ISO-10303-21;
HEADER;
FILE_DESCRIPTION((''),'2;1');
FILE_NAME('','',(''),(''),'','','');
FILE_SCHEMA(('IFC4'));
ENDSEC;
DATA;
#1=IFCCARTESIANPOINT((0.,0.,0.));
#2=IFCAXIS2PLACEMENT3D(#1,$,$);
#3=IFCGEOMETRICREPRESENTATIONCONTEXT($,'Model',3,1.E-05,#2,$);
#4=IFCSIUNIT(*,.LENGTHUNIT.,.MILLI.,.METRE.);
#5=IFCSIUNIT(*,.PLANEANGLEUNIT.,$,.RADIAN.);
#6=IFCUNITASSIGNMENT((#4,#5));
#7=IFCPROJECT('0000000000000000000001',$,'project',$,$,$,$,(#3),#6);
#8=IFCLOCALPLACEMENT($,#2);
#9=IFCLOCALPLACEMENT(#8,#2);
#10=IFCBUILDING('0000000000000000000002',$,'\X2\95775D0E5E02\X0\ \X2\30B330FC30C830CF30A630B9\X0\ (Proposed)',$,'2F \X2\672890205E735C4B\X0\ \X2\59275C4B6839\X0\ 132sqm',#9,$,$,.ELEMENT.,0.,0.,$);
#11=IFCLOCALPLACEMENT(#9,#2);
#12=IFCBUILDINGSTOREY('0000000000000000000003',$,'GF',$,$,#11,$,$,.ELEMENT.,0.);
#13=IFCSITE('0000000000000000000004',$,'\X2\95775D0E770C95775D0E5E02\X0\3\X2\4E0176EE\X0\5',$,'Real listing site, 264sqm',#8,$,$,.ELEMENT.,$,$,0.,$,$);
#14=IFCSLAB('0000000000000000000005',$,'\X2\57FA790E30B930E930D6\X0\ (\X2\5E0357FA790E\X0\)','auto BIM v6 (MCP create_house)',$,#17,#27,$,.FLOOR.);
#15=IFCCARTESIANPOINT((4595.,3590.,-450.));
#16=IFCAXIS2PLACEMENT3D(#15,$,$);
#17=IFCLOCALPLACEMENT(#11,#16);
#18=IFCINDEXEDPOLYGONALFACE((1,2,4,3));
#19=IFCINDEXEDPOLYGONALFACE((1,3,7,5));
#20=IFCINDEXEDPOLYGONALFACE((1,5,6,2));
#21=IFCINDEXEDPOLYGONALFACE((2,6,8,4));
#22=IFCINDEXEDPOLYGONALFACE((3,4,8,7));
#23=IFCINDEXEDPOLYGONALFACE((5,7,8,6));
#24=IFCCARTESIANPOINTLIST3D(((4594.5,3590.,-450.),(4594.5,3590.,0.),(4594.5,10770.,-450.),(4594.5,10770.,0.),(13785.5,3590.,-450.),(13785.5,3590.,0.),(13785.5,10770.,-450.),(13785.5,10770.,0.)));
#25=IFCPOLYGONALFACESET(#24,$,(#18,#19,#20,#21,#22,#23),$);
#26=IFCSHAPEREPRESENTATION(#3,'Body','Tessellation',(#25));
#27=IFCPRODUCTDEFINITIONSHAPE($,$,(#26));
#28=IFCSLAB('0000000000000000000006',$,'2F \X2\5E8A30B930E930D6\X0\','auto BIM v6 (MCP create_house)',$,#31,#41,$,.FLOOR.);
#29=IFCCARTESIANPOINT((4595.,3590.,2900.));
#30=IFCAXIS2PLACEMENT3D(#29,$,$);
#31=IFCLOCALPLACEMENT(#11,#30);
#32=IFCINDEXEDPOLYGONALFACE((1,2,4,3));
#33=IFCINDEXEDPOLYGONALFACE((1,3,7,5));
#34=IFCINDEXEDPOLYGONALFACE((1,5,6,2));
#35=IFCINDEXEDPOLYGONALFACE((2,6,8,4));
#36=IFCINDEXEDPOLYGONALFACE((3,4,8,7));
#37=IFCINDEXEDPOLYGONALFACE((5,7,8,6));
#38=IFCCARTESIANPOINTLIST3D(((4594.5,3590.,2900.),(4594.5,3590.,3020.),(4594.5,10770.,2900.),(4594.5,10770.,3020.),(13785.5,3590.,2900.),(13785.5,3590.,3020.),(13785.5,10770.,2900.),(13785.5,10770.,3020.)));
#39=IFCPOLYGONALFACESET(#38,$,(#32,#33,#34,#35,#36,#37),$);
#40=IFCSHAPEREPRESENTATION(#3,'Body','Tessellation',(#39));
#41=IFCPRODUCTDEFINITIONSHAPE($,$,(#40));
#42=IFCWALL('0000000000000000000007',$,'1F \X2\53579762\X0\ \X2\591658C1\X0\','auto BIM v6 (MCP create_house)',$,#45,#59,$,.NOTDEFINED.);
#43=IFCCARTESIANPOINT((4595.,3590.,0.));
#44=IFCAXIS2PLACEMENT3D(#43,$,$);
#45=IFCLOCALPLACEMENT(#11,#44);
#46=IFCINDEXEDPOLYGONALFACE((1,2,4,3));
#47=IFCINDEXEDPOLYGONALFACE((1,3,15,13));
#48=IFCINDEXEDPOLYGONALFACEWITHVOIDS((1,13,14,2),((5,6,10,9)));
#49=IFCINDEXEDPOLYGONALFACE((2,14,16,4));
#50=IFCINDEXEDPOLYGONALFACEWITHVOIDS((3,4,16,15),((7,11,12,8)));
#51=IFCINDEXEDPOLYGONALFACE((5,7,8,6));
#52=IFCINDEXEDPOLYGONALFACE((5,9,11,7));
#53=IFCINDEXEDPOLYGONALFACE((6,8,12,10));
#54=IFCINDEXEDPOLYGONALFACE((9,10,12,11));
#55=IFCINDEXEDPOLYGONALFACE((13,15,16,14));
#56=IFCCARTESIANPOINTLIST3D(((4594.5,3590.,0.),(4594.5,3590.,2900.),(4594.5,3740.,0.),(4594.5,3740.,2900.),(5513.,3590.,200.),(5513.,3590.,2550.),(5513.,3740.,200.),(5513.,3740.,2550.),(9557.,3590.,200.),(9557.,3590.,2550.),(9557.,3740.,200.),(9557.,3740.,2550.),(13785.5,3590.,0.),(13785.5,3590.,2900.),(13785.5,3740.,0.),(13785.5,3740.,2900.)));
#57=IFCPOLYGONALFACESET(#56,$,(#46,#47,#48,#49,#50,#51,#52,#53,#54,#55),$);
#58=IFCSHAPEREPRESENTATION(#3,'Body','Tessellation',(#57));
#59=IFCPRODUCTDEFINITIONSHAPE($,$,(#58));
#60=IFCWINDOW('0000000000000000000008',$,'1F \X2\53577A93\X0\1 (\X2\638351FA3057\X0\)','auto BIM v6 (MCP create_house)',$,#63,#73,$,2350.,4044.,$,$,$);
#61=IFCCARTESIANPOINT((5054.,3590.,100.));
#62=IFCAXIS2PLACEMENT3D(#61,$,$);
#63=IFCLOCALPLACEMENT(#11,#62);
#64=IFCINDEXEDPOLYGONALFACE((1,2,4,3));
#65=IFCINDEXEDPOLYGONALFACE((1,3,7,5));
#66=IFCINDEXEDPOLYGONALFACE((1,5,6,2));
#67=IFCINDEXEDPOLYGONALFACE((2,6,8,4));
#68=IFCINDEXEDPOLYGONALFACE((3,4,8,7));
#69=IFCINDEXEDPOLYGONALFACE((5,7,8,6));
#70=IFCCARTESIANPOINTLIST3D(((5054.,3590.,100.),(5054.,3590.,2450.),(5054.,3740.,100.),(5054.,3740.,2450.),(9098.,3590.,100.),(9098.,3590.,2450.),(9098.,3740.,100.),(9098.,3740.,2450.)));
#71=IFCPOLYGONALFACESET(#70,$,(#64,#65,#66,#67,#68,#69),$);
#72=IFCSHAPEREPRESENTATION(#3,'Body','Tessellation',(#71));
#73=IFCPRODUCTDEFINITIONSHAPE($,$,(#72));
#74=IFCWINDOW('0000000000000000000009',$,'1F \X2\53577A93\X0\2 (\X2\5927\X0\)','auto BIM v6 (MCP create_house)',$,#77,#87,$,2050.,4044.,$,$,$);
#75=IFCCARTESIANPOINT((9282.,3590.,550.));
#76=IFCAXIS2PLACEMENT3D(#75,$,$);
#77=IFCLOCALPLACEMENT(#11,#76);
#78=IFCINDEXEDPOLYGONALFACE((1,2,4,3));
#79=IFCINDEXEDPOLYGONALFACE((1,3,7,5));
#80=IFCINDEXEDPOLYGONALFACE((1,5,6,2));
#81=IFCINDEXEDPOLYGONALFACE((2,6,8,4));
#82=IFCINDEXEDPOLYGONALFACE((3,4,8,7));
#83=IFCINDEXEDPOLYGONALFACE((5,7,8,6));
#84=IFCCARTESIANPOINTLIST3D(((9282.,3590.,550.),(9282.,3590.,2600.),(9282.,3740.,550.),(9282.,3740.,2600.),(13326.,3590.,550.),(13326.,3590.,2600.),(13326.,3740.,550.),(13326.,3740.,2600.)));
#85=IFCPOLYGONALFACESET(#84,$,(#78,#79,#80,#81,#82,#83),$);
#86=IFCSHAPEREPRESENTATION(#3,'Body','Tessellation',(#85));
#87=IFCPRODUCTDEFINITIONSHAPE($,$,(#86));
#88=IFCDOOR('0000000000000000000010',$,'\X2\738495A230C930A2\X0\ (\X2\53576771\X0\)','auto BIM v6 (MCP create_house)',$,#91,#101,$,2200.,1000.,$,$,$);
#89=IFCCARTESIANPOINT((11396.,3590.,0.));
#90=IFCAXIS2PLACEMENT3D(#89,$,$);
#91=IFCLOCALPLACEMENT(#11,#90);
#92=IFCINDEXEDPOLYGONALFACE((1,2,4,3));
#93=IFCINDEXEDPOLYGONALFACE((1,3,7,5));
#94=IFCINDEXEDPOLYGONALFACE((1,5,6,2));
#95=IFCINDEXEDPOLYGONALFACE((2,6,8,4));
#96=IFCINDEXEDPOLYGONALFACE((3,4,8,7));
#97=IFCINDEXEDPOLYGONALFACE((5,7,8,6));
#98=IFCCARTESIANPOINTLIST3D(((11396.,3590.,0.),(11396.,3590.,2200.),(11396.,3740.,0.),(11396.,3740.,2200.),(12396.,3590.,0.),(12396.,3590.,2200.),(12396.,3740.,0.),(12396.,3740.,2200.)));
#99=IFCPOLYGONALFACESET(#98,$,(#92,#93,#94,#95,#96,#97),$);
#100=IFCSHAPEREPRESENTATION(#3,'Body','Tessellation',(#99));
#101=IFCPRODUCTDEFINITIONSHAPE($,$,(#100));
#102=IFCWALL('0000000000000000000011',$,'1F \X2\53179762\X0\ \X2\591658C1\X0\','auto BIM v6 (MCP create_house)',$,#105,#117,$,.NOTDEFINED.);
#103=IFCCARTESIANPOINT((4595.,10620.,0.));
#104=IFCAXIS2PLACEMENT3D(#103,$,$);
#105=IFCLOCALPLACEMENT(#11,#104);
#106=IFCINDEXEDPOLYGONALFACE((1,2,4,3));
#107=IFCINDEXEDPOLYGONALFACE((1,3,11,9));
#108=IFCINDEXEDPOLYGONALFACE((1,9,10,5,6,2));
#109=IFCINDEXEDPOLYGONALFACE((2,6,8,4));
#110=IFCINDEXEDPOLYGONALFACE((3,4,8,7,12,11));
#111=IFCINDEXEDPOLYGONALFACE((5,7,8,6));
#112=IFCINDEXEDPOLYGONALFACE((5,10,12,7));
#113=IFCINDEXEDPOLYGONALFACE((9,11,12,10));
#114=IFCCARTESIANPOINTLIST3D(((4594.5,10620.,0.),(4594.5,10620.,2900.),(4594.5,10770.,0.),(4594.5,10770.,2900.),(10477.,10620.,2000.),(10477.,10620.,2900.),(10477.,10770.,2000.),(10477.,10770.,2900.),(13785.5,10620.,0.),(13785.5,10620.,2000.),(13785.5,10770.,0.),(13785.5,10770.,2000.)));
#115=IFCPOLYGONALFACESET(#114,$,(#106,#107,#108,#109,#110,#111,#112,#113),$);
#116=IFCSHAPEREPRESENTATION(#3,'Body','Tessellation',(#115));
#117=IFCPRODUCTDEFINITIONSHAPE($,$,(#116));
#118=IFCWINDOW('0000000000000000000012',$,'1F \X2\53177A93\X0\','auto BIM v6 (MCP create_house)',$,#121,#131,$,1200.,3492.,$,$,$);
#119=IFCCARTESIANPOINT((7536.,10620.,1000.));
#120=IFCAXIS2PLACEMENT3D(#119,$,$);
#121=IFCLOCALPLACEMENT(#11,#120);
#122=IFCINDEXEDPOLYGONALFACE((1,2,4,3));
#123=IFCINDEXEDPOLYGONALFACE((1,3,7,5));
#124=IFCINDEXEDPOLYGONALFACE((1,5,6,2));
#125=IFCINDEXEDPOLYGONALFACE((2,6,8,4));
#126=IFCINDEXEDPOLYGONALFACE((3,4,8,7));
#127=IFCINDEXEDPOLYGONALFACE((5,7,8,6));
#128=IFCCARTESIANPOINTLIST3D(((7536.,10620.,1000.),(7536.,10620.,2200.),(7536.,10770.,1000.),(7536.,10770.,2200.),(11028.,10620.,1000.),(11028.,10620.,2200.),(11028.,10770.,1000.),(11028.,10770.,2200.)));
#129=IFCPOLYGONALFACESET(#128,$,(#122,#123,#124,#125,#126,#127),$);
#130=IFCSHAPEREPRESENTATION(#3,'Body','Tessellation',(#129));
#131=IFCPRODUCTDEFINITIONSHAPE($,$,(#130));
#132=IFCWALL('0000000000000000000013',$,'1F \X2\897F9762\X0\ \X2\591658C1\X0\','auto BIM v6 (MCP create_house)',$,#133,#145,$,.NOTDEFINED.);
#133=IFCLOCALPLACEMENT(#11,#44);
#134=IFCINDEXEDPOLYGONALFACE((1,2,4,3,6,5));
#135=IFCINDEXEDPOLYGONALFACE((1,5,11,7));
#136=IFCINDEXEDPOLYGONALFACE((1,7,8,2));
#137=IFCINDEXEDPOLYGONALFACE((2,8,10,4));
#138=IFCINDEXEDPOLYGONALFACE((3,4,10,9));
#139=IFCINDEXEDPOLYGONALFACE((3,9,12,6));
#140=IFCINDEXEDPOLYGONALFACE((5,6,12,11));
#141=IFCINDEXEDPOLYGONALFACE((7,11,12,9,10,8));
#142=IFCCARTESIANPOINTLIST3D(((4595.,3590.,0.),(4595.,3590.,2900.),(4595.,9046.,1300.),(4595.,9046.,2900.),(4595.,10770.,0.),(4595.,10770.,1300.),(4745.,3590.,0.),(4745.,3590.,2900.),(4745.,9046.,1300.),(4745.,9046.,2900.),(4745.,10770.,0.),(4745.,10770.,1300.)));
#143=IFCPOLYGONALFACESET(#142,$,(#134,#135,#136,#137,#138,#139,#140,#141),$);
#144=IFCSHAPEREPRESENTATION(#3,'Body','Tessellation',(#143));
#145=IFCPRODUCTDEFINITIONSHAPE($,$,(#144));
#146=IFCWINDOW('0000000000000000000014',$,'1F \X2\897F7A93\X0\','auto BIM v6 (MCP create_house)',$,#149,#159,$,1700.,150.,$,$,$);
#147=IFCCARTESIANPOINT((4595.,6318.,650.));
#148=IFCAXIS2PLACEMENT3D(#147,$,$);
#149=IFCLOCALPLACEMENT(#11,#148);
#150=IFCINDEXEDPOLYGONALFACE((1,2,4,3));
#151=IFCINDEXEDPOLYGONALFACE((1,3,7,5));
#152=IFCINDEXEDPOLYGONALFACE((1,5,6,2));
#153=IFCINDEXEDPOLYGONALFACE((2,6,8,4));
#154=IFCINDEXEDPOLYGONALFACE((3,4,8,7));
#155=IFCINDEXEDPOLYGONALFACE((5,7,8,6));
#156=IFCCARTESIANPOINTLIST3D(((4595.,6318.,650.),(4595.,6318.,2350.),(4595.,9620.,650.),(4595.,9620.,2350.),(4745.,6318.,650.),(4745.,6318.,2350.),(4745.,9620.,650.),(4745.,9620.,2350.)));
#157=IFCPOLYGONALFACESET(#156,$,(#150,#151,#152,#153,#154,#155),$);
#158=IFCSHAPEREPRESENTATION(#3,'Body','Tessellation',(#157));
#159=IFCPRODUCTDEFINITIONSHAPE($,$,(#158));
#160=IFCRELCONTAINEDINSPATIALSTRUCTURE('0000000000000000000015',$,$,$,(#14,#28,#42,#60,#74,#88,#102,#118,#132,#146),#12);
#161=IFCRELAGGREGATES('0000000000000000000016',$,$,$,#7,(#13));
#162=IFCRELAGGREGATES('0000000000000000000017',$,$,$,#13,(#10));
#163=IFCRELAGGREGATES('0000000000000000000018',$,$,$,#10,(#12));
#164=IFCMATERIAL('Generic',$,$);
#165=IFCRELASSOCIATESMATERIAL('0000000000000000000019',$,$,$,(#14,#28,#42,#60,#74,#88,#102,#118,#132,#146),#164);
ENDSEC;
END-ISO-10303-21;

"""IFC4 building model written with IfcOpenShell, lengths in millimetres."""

from ifc_helpers import new_model, si_unit, frame, frame_2d, origin, place, context, project, spatial, rectangle, extrude, material, element, fill, save


model = new_model("IFC4")

# Units and contexts
model_context = context("Model", 3, precision=1e-05, world=origin())
ifc_project = project(units=[si_unit("LENGTHUNIT", "METRE", prefix="MILLI"), si_unit("PLANEANGLEUNIT", "RADIAN")], contexts=[model_context])

# Site, building, storey
site_placement = place(None, origin())
site = spatial("IfcSite", under=ifc_project, at=site_placement, Name="長崎県長崎市3丁目5", ObjectType="Real listing site, 264sqm", CompositionType="ELEMENT", RefElevation=0.0)
building_placement = place(site_placement, origin())
building = spatial("IfcBuilding", under=site, at=building_placement, Name="長崎市 コートハウス (Proposed)", ObjectType="2F 木造平屋 大屋根 132sqm", CompositionType="ELEMENT", ElevationOfRefHeight=0.0, ElevationOfTerrain=0.0)
storey_placement = place(building_placement, origin())
storey = spatial("IfcBuildingStorey", under=building, at=storey_placement, Name="GF", CompositionType="ELEMENT", Elevation=0.0)

# Slabs
ifc_material = material(Name="Generic")
slab_1_placement = place(storey_placement, frame((4595.0, 3590.0, -450.0)))
element("IfcSlab", 1, at=slab_1_placement, inside=storey, material=ifc_material, Name="基礎スラブ (布基礎)", Description="auto BIM v6 (MCP create_house)", PredefinedType="FLOOR", context=model_context, shape_type="SweptSolid", body=[
    extrude(rectangle(XDim=9191.0, YDim=7180.0, at=frame_2d((4595.0, 3590.0))), frame((4595.0, 3590.0, -450.0)), (0.0, 0.0, 1.0), 450.0),
])
slab_2_placement = place(storey_placement, frame((4595.0, 3590.0, 2900.0)))
element("IfcSlab", 2, at=slab_2_placement, inside=storey, material=ifc_material, Name="2F 床スラブ", Description="auto BIM v6 (MCP create_house)", PredefinedType="FLOOR", context=model_context, shape_type="SweptSolid", body=[
    extrude(rectangle(XDim=9191.0, YDim=7180.0, at=frame_2d((4595.0, 3590.0))), frame((4595.0, 3590.0, 2900.0)), (0.0, 0.0, 1.0), 120.0),
])

# Wall, openings, windows, door
wall_1_placement = place(storey_placement, frame((4595.0, 3590.0, 0.0)))
wall_1 = element("IfcWall", 3, at=wall_1_placement, inside=storey, material=ifc_material, Name="1F 南面 外壁", Description="auto BIM v6 (MCP create_house)", PredefinedType="NOTDEFINED", context=model_context, shape_type="SweptSolid", body=[
    extrude(rectangle(XDim=9191.0, YDim=150.0, at=frame_2d((4595.0, 75.0))), frame((4595.0, 3590.0, 0.0)), (0.0, 0.0, 1.0), 2900.0),
])
opening_1_placement = place(storey_placement, frame((5054.0, 3590.0, 100.0)))
opening_1 = element("IfcOpeningElement", 4, at=opening_1_placement, cuts=wall_1, PredefinedType="NOTDEFINED", context=model_context, shape_type="SweptSolid", body=[
    extrude(rectangle(XDim=4044.0, YDim=150.0, at=frame_2d((2022.0, 75.0))), frame((5054.0, 3590.0, 100.0)), (0.0, 0.0, 1.0), 2350.0),
])
opening_2_placement = place(storey_placement, frame((9282.0, 3590.0, 550.0)))
opening_2 = element("IfcOpeningElement", 5, at=opening_2_placement, cuts=wall_1, PredefinedType="NOTDEFINED", context=model_context, shape_type="SweptSolid", body=[
    extrude(rectangle(XDim=4044.0, YDim=150.0, at=frame_2d((2022.0, 75.0))), frame((9282.0, 3590.0, 550.0)), (0.0, 0.0, 1.0), 2050.0),
])
opening_3_placement = place(storey_placement, frame((11396.0, 3590.0, 0.0)))
opening_3 = element("IfcOpeningElement", 6, at=opening_3_placement, cuts=wall_1, PredefinedType="NOTDEFINED", context=model_context, shape_type="SweptSolid", body=[
    extrude(rectangle(XDim=1000.0, YDim=150.0, at=frame_2d((500.0, 75.0))), frame((11396.0, 3590.0, 0.0)), (0.0, 0.0, 1.0), 2200.0),
])
window_1_placement = place(storey_placement, frame((5054.0, 3590.0, 100.0)))
window_1 = element("IfcWindow", 7, at=window_1_placement, inside=storey, material=ifc_material, Name="1F 南窓1 (掃出し)", Description="auto BIM v6 (MCP create_house)", OverallHeight=2350.0, OverallWidth=4044.0, context=model_context, shape_type="SweptSolid", body=[
    extrude(rectangle(XDim=4044.0, YDim=150.0, at=frame_2d((2022.0, 75.0))), frame((5054.0, 3590.0, 100.0)), (0.0, 0.0, 1.0), 2350.0),
])
fill(opening_1, window_1)
window_2_placement = place(storey_placement, frame((9282.0, 3590.0, 550.0)))
window_2 = element("IfcWindow", 8, at=window_2_placement, inside=storey, material=ifc_material, Name="1F 南窓2 (大)", Description="auto BIM v6 (MCP create_house)", OverallHeight=2050.0, OverallWidth=4044.0, context=model_context, shape_type="SweptSolid", body=[
    extrude(rectangle(XDim=4044.0, YDim=150.0, at=frame_2d((2022.0, 75.0))), frame((9282.0, 3590.0, 550.0)), (0.0, 0.0, 1.0), 2050.0),
])
fill(opening_2, window_2)
door_placement = place(storey_placement, frame((11396.0, 3590.0, 0.0)))
door = element("IfcDoor", 9, at=door_placement, inside=storey, material=ifc_material, Name="玄関ドア (南東)", Description="auto BIM v6 (MCP create_house)", OverallHeight=2200.0, OverallWidth=1000.0, context=model_context, shape_type="SweptSolid", body=[
    extrude(rectangle(XDim=1000.0, YDim=150.0, at=frame_2d((500.0, 75.0))), frame((11396.0, 3590.0, 0.0)), (0.0, 0.0, 1.0), 2200.0),
])
fill(opening_3, door)

# Walls, openings, windows
wall_2_placement = place(storey_placement, frame((4595.0, 10620.0, 0.0)))
wall_2 = element("IfcWall", 10, at=wall_2_placement, inside=storey, material=ifc_material, Name="1F 北面 外壁", Description="auto BIM v6 (MCP create_house)", PredefinedType="NOTDEFINED", context=model_context, shape_type="SweptSolid", body=[
    extrude(rectangle(XDim=9191.0, YDim=150.0, at=frame_2d((4595.0, 75.0))), frame((4595.0, 10620.0, 0.0)), (0.0, 0.0, 1.0), 2900.0),
])
opening_4_placement = place(storey_placement, frame((7536.0, 10620.0, 1000.0)))
opening_4 = element("IfcOpeningElement", 11, at=opening_4_placement, cuts=wall_2, PredefinedType="NOTDEFINED", context=model_context, shape_type="SweptSolid", body=[
    extrude(rectangle(XDim=3492.0, YDim=150.0, at=frame_2d((1746.0, 75.0))), frame((7536.0, 10620.0, 1000.0)), (0.0, 0.0, 1.0), 1200.0),
])
window_3_placement = place(storey_placement, frame((7536.0, 10620.0, 1000.0)))
window_3 = element("IfcWindow", 12, at=window_3_placement, inside=storey, material=ifc_material, Name="1F 北窓", Description="auto BIM v6 (MCP create_house)", OverallHeight=1200.0, OverallWidth=3492.0, context=model_context, shape_type="SweptSolid", body=[
    extrude(rectangle(XDim=3492.0, YDim=150.0, at=frame_2d((1746.0, 75.0))), frame((7536.0, 10620.0, 1000.0)), (0.0, 0.0, 1.0), 1200.0),
])
fill(opening_4, window_3)
wall_3_placement = place(storey_placement, frame((4595.0, 3590.0, 0.0)))
wall_3 = element("IfcWall", 13, at=wall_3_placement, inside=storey, material=ifc_material, Name="1F 西面 外壁", Description="auto BIM v6 (MCP create_house)", PredefinedType="NOTDEFINED", context=model_context, shape_type="SweptSolid", body=[
    extrude(rectangle(XDim=150.0, YDim=7180.0, at=frame_2d((75.0, 3590.0))), frame((4595.0, 3590.0, 0.0)), (0.0, 0.0, 1.0), 2900.0),
])
opening_5_placement = place(storey_placement, frame((4595.0, 6318.0, 650.0)))
opening_5 = element("IfcOpeningElement", 14, at=opening_5_placement, cuts=wall_3, PredefinedType="NOTDEFINED", context=model_context, shape_type="SweptSolid", body=[
    extrude(rectangle(XDim=150.0, YDim=3302.0, at=frame_2d((75.0, 1651.0))), frame((4595.0, 6318.0, 650.0)), (0.0, 0.0, 1.0), 1700.0),
])
window_4_placement = place(storey_placement, frame((4595.0, 6318.0, 650.0)))
window_4 = element("IfcWindow", 15, at=window_4_placement, inside=storey, material=ifc_material, Name="1F 西窓", Description="auto BIM v6 (MCP create_house)", OverallHeight=1700.0, OverallWidth=150.0, context=model_context, shape_type="SweptSolid", body=[
    extrude(rectangle(XDim=150.0, YDim=3302.0, at=frame_2d((75.0, 1651.0))), frame((4595.0, 6318.0, 650.0)), (0.0, 0.0, 1.0), 1700.0),
])
fill(opening_5, window_4)

save(model, "model.ifc")
